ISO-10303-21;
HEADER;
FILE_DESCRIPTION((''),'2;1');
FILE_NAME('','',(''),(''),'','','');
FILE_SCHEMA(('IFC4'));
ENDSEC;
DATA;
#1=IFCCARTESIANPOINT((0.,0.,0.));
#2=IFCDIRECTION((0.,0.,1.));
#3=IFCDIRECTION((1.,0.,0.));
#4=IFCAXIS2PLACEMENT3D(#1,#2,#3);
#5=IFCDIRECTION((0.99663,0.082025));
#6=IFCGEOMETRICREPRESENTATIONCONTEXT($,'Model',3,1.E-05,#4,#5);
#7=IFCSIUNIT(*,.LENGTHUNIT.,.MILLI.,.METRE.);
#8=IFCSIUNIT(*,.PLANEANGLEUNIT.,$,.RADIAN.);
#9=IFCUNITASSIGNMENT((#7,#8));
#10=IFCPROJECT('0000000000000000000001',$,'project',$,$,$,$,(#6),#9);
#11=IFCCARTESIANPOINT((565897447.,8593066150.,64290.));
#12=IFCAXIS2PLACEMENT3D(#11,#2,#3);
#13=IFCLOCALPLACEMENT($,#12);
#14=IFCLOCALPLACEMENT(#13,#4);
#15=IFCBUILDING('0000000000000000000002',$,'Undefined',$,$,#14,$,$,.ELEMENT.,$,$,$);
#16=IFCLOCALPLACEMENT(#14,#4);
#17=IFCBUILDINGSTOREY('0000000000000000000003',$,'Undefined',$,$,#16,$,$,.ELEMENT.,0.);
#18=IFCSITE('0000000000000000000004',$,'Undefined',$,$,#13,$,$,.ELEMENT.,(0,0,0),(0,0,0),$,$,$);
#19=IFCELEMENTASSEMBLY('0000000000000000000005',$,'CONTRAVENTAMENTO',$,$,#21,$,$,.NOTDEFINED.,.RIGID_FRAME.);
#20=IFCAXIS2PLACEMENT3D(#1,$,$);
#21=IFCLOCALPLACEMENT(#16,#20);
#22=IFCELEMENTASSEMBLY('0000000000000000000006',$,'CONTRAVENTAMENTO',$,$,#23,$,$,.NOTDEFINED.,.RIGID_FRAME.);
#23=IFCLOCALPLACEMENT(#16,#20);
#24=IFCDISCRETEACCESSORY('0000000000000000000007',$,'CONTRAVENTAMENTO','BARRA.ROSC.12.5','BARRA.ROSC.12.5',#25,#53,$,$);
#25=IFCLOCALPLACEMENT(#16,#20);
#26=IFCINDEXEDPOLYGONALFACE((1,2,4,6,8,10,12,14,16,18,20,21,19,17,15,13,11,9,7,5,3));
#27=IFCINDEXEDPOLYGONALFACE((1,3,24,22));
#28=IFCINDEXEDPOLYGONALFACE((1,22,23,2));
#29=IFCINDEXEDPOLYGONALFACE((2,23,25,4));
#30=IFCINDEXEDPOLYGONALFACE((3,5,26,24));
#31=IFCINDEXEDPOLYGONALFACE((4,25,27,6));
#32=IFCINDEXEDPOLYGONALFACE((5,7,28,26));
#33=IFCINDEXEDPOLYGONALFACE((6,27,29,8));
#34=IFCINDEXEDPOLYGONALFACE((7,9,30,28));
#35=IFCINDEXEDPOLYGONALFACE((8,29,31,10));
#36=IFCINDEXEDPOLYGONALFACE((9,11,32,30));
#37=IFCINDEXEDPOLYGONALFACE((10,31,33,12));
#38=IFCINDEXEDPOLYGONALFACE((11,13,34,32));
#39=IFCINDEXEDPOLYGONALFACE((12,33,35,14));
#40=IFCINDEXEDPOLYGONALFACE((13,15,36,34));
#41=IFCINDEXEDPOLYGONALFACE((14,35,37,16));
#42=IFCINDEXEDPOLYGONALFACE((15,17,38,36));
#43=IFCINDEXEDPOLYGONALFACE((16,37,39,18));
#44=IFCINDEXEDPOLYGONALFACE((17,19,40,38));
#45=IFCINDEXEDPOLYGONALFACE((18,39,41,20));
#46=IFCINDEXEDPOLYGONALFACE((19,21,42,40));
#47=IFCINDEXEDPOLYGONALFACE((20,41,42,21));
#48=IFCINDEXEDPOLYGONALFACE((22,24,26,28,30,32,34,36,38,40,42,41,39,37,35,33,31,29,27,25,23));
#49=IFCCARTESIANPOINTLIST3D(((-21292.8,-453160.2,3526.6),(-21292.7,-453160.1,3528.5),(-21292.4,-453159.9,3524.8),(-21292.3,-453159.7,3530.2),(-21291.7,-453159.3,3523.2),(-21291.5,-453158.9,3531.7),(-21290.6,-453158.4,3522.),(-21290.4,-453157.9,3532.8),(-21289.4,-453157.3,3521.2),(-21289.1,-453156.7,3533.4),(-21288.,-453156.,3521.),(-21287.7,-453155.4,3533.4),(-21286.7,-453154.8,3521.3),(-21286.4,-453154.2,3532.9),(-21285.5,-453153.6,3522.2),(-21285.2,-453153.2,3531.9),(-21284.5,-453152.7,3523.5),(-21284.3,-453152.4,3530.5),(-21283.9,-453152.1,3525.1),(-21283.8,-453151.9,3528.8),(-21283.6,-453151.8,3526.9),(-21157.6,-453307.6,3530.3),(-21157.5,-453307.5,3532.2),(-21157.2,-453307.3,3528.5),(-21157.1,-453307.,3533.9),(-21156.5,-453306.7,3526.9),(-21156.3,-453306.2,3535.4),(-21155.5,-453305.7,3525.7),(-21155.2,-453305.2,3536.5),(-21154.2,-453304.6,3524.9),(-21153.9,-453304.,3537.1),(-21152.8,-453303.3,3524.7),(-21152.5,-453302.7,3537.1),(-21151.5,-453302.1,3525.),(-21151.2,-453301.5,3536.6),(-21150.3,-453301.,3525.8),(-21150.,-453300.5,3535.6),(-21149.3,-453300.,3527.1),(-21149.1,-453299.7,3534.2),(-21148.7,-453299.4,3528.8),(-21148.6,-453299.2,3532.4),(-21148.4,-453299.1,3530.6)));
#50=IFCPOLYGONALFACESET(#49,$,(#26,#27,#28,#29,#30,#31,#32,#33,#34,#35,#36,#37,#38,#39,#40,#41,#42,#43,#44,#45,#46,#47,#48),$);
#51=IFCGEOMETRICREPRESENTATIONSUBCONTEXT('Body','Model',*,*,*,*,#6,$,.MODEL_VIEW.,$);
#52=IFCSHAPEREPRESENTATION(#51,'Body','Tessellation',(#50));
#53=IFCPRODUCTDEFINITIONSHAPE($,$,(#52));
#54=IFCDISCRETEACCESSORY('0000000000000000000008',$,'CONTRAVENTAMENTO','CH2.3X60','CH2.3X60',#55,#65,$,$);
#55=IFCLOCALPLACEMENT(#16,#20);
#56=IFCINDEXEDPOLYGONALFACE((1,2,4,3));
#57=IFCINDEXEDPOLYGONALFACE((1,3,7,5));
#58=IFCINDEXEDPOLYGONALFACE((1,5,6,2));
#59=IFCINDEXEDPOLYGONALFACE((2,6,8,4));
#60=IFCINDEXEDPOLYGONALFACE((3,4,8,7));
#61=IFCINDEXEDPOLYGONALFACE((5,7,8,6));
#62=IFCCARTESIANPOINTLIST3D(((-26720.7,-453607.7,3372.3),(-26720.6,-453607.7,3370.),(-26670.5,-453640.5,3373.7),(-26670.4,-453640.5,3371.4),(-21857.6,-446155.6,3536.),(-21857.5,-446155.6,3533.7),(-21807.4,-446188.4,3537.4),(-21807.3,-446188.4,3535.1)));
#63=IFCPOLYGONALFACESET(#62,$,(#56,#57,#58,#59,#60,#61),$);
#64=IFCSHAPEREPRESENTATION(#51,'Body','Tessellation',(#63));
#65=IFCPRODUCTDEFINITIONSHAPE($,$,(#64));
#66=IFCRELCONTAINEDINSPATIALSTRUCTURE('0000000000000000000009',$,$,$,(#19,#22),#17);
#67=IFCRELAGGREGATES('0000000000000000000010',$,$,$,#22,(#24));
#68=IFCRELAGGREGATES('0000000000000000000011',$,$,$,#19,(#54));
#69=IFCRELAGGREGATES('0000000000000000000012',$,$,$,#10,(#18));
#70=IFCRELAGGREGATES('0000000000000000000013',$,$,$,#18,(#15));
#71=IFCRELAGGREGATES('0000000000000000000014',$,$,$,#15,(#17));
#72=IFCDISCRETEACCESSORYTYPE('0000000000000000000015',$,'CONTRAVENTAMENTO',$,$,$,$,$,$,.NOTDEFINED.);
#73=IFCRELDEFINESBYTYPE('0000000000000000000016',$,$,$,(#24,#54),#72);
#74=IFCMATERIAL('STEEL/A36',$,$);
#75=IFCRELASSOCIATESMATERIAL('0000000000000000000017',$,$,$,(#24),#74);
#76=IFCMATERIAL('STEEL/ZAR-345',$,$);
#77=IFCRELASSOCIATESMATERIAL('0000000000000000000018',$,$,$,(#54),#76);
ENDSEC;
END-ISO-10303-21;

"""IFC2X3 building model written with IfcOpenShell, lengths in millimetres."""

from ifc_helpers import new_model, si_unit, direction, frame, origin_with_axes, origin_2d_with_axis, place, context, subcontext, project, spatial, polyline, circle, outline, extrude, material, type_object, element, aggregate, save


model = new_model("IFC2X3")

# Units and contexts
model_context = context("Model", 3, precision=1e-05, world=origin_with_axes(), true_north=direction((0.99663, 0.082025)))
body_context = subcontext(model_context, "Body", "Model", "MODEL_VIEW")
ifc_project = project(units=[si_unit("LENGTHUNIT", "METRE", prefix="MILLI"), si_unit("PLANEANGLEUNIT", "RADIAN")], contexts=[model_context])

# Site, building, storey
site_placement = place(None, frame((565897447.0, 8593066150.0, 64290.0), z_axis=(0.0, 0.0, 1.0), x_axis=(1.0, 0.0, 0.0)))
site = spatial("IfcSite", under=ifc_project, at=site_placement, Name="Undefined", CompositionType="ELEMENT", RefLatitude=(0, 0, 0), RefLongitude=(0, 0, 0))
building_placement = place(site_placement, origin_with_axes())
building = spatial("IfcBuilding", under=site, at=building_placement, Name="Undefined", CompositionType="ELEMENT")
storey_placement = place(building_placement, origin_with_axes())
storey = spatial("IfcBuildingStorey", under=building, at=storey_placement, Name="Undefined", CompositionType="ELEMENT", Elevation=0.0)

# Shared definitions
ifc_material_1 = material(Name="STEEL/A36")

# Element assemblies, discrete accessory
assembly_1_placement = place(storey_placement, origin_with_axes())
assembly_1 = element("IfcElementAssembly", 1, at=assembly_1_placement, inside=storey, Name="CONTRAVENTAMENTO", AssemblyPlace="NOTDEFINED", PredefinedType="RIGID_FRAME")
discrete_accessory_type_1 = type_object("IfcDiscreteAccessoryType", Name="CONTRAVENTAMENTO")
assembly_2_placement = place(storey_placement, origin_with_axes())
assembly_2 = element("IfcElementAssembly", 2, at=assembly_2_placement, inside=storey, Name="CONTRAVENTAMENTO", AssemblyPlace="NOTDEFINED", PredefinedType="RIGID_FRAME")
discrete_accessory_1_placement = place(assembly_2_placement, frame((-21153.0, -453303.4, 3530.9), z_axis=(0.736334, 0.676203, 0.02368), x_axis=(-0.675958, 0.736711, -0.018398)))
discrete_accessory_1 = element("IfcDiscreteAccessory", 3, at=discrete_accessory_1_placement, type_object=discrete_accessory_type_1, material=ifc_material_1, Name="CONTRAVENTAMENTO", Description="BARRA.ROSC.12.5", ObjectType="BARRA.ROSC.12.5", context=body_context, shape_type="SweptSolid", body=[
    extrude(circle(Radius=6.2, at=origin_2d_with_axis()), frame((200.0, 0.0, 0.0), z_axis=(-1.0, 0.0, 0.0), x_axis=(0.0, -1.0, 0.0)), (0.0, 0.0, 1.0), 200.0),
])
aggregate(assembly_2, [discrete_accessory_1])

# Discrete accessory
ifc_material_2 = material(Name="STEEL/ZAR-345")
discrete_accessory_2_placement = place(assembly_1_placement, frame((-26695.5, -453624.1, 3371.8), z_axis=(0.029885, 0.00246, -0.99955), x_axis=(0.546411, 0.837315, 0.018398)))
discrete_accessory_2 = element("IfcDiscreteAccessory", 4, at=discrete_accessory_2_placement, type_object=discrete_accessory_type_1, material=ifc_material_2, Name="CONTRAVENTAMENTO", Description="CH2.3X60", ObjectType="CH2.3X60", context=body_context, shape_type="SweptSolid", body=[
    extrude(outline(polyline([(8900.0, -30.0), (0.0, -30.0), (0.0, 30.0), (8900.0, 30.0), (8900.0, -30.0)])), frame((0.0, 0.0, -1.1), z_axis=(0.0, 0.0, 1.0), x_axis=(1.0, 0.0, 0.0)), (0.0, 0.0, 1.0), 2.3),
])
aggregate(assembly_1, [discrete_accessory_2])

save(model, "model.ifc")
